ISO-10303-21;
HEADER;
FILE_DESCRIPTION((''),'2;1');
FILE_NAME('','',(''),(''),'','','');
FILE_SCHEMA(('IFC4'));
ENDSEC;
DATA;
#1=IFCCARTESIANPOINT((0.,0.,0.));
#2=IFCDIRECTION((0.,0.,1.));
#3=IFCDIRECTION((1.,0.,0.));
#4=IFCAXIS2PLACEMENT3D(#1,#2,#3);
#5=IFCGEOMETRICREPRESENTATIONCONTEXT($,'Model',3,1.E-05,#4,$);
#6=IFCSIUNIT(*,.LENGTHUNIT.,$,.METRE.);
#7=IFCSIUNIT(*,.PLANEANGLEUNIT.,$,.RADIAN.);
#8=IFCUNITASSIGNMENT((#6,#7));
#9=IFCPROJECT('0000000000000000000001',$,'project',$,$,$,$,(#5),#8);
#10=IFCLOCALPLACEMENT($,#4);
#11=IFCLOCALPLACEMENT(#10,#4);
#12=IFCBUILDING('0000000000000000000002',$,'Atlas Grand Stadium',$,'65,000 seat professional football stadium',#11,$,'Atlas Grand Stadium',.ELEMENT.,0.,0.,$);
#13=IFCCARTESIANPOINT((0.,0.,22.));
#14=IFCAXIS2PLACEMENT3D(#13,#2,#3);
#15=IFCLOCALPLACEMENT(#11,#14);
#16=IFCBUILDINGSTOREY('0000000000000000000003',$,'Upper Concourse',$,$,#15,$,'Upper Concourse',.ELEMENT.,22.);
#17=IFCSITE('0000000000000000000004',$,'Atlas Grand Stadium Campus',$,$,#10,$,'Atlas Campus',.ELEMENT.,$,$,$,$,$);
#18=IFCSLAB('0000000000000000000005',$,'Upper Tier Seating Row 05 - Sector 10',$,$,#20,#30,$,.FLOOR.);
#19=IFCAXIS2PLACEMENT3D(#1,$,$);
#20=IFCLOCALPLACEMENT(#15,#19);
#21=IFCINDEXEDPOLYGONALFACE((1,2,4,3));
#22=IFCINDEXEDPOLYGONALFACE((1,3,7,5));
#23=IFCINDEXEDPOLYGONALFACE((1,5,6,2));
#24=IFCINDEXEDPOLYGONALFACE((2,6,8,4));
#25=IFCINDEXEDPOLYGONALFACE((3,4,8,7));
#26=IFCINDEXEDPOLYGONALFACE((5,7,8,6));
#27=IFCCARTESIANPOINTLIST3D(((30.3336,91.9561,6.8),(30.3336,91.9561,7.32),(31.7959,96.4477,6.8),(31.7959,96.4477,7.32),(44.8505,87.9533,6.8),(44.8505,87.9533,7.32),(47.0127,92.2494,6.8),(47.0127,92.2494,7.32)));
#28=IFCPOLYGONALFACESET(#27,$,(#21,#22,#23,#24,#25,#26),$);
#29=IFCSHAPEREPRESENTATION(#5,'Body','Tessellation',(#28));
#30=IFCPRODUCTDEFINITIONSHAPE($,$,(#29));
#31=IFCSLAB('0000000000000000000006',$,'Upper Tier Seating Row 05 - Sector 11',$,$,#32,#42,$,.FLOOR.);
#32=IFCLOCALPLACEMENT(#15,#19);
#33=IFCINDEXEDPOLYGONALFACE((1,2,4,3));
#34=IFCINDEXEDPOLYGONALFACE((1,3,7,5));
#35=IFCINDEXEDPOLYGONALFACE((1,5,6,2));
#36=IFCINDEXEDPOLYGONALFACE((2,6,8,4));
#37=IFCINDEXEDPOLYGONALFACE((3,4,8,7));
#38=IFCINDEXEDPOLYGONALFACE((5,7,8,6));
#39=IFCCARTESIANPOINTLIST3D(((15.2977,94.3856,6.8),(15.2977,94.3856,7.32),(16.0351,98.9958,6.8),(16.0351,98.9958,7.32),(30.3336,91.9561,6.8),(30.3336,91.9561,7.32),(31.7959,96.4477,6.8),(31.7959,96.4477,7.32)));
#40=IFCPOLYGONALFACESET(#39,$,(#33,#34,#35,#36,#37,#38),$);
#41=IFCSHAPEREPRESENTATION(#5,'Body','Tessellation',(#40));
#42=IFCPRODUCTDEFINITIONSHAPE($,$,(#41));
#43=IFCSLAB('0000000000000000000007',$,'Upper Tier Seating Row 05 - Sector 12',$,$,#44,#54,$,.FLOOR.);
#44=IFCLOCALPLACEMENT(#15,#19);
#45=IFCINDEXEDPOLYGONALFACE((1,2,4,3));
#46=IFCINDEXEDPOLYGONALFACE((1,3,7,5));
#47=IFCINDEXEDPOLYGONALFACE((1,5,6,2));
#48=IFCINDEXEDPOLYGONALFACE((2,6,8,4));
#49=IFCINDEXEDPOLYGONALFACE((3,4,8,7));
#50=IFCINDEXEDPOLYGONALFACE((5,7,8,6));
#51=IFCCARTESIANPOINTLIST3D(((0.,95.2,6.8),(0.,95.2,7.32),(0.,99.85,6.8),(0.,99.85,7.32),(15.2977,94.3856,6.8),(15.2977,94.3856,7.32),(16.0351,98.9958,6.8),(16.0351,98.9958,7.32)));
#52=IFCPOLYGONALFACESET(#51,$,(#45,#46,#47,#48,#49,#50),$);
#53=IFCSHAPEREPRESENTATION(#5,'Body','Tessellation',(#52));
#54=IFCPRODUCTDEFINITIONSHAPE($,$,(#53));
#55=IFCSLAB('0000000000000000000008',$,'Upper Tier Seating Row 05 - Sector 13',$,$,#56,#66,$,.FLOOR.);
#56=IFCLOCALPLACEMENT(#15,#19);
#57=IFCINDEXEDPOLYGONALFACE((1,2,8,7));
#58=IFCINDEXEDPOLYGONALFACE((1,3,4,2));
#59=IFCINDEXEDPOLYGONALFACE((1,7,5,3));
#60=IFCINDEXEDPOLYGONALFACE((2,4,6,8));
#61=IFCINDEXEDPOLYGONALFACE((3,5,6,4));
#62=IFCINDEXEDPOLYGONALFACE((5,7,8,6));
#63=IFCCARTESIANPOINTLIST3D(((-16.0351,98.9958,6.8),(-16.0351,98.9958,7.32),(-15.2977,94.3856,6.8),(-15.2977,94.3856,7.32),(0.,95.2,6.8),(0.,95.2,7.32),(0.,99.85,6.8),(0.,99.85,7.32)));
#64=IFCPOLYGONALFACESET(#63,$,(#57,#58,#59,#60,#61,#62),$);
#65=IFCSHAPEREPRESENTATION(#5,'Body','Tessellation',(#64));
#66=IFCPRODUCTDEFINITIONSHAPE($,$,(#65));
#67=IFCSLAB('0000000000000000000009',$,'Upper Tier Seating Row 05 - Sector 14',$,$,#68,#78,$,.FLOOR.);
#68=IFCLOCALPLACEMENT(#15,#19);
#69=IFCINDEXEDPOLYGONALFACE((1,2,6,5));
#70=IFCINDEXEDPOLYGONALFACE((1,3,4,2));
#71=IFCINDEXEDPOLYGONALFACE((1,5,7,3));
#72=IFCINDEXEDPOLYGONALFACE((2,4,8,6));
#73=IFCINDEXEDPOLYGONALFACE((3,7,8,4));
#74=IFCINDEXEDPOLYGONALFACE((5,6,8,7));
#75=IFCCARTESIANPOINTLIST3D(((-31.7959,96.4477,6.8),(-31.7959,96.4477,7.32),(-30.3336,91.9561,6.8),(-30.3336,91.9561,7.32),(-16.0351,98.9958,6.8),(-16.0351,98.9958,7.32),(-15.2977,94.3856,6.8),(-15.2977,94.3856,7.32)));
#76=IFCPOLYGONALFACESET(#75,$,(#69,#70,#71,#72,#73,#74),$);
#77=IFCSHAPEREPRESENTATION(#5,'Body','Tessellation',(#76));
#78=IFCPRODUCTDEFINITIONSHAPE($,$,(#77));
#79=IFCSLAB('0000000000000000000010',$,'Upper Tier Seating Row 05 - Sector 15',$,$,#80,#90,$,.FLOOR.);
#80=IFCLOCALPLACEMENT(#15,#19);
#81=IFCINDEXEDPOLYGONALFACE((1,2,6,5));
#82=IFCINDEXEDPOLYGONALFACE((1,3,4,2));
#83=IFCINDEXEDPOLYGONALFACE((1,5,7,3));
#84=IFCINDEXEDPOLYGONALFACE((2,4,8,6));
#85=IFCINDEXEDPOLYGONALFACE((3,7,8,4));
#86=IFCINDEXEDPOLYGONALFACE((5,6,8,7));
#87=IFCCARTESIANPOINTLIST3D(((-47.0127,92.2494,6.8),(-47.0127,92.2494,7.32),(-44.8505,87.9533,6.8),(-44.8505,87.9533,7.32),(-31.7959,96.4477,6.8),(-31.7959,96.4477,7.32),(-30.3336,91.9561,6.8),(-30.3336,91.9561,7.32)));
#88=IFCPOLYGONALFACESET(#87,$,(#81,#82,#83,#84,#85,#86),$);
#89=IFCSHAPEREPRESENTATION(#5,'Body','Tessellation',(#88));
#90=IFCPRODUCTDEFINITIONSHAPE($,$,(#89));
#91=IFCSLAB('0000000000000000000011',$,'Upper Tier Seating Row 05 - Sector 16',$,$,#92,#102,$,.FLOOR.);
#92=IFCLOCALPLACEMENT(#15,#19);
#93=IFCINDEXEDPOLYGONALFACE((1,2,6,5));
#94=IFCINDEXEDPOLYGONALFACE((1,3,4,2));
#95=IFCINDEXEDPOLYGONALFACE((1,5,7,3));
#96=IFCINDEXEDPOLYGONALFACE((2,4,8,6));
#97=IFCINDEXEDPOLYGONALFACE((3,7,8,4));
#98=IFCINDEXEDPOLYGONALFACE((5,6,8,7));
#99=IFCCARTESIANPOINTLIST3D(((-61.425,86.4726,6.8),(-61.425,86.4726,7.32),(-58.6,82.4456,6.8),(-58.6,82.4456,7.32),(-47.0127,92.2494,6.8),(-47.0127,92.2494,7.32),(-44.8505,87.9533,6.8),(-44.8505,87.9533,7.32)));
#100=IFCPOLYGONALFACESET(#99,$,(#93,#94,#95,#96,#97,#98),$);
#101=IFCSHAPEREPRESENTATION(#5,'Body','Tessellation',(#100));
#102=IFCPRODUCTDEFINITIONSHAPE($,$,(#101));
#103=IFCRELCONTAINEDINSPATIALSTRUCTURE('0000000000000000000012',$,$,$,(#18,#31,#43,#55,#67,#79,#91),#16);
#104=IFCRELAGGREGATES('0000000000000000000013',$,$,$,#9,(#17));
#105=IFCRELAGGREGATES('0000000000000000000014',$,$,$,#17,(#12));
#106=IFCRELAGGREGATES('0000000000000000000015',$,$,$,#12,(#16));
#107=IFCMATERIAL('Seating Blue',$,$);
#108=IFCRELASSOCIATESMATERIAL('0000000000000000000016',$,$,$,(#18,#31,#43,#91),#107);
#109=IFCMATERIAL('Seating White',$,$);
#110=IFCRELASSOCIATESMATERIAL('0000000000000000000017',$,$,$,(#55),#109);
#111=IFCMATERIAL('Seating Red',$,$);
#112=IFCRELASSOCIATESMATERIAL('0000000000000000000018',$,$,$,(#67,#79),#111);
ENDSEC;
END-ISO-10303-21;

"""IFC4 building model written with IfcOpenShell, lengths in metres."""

from ifc_helpers import new_model, si_unit, frame, origin_with_axes, place, context, project, spatial, polyline, outline, extrude, material, element, save


model = new_model("IFC4")

# Units and contexts
model_context = context("Model", 3, precision=1e-05, world=origin_with_axes())
ifc_project = project(units=[si_unit("LENGTHUNIT", "METRE"), si_unit("PLANEANGLEUNIT", "RADIAN")], contexts=[model_context])

# Site, building, storey
site_placement = place(None, origin_with_axes())
site = spatial("IfcSite", under=ifc_project, at=site_placement, Name="Atlas Grand Stadium Campus", LongName="Atlas Campus", CompositionType="ELEMENT")
building_placement = place(site_placement, origin_with_axes())
building = spatial("IfcBuilding", under=site, at=building_placement, Name="Atlas Grand Stadium", ObjectType="65,000 seat professional football stadium", LongName="Atlas Grand Stadium", CompositionType="ELEMENT", ElevationOfRefHeight=0.0, ElevationOfTerrain=0.0)
storey_placement = place(building_placement, frame((0.0, 0.0, 22.0), z_axis=(0.0, 0.0, 1.0), x_axis=(1.0, 0.0, 0.0)))
storey = spatial("IfcBuildingStorey", under=building, at=storey_placement, Name="Upper Concourse", LongName="Upper Concourse", CompositionType="ELEMENT", Elevation=22.0)

# Slabs
ifc_material_1 = material(Name="Seating Blue")
ifc_material_2 = material(Name="Seating White")
ifc_material_3 = material(Name="Seating Red")
slab_1_placement = place(storey_placement, frame((0.0, 0.0, 6.8), z_axis=(0.0, 0.0, 1.0), x_axis=(1.0, 0.0, 0.0)))
element("IfcSlab", 1, at=slab_1_placement, inside=storey, material=ifc_material_1, Name="Upper Tier Seating Row 05 - Sector 10", PredefinedType="FLOOR", context=model_context, shape_type="SweptSolid", body=[
    extrude(outline(polyline([(47.0127, 92.2494), (31.7959, 96.4477), (30.3336, 91.9561), (44.8505, 87.9533), (47.0127, 92.2494)])), origin_with_axes(), (0.0, 0.0, 1.0), 0.52),
])
slab_2_placement = place(storey_placement, frame((0.0, 0.0, 6.8), z_axis=(0.0, 0.0, 1.0), x_axis=(1.0, 0.0, 0.0)))
element("IfcSlab", 2, at=slab_2_placement, inside=storey, material=ifc_material_1, Name="Upper Tier Seating Row 05 - Sector 11", PredefinedType="FLOOR", context=model_context, shape_type="SweptSolid", body=[
    extrude(outline(polyline([(31.7959, 96.4477), (16.0351, 98.9958), (15.2977, 94.3855), (30.3336, 91.9561), (31.7959, 96.4477)])), origin_with_axes(), (0.0, 0.0, 1.0), 0.52),
])
slab_3_placement = place(storey_placement, frame((0.0, 0.0, 6.8), z_axis=(0.0, 0.0, 1.0), x_axis=(1.0, 0.0, 0.0)))
element("IfcSlab", 3, at=slab_3_placement, inside=storey, material=ifc_material_1, Name="Upper Tier Seating Row 05 - Sector 12", PredefinedType="FLOOR", context=model_context, shape_type="SweptSolid", body=[
    extrude(outline(polyline([(16.0351, 98.9958), (0.0, 99.85), (0.0, 95.2), (15.2977, 94.3855), (16.0351, 98.9958)])), origin_with_axes(), (0.0, 0.0, 1.0), 0.52),
])
slab_4_placement = place(storey_placement, frame((0.0, 0.0, 6.8), z_axis=(0.0, 0.0, 1.0), x_axis=(1.0, 0.0, 0.0)))
element("IfcSlab", 4, at=slab_4_placement, inside=storey, material=ifc_material_2, Name="Upper Tier Seating Row 05 - Sector 13", PredefinedType="FLOOR", context=model_context, shape_type="SweptSolid", body=[
    extrude(outline(polyline([(0.0, 99.85), (-16.0351, 98.9958), (-15.2977, 94.3855), (0.0, 95.2), (0.0, 99.85)])), origin_with_axes(), (0.0, 0.0, 1.0), 0.52),
])
slab_5_placement = place(storey_placement, frame((0.0, 0.0, 6.8), z_axis=(0.0, 0.0, 1.0), x_axis=(1.0, 0.0, 0.0)))
element("IfcSlab", 5, at=slab_5_placement, inside=storey, material=ifc_material_3, Name="Upper Tier Seating Row 05 - Sector 14", PredefinedType="FLOOR", context=model_context, shape_type="SweptSolid", body=[
    extrude(outline(polyline([(-16.0351, 98.9958), (-31.7959, 96.4477), (-30.3336, 91.9561), (-15.2977, 94.3855), (-16.0351, 98.9958)])), origin_with_axes(), (0.0, 0.0, 1.0), 0.52),
])
slab_6_placement = place(storey_placement, frame((0.0, 0.0, 6.8), z_axis=(0.0, 0.0, 1.0), x_axis=(1.0, 0.0, 0.0)))
element("IfcSlab", 6, at=slab_6_placement, inside=storey, material=ifc_material_3, Name="Upper Tier Seating Row 05 - Sector 15", PredefinedType="FLOOR", context=model_context, shape_type="SweptSolid", body=[
    extrude(outline(polyline([(-31.7959, 96.4477), (-47.0127, 92.2494), (-44.8505, 87.9533), (-30.3336, 91.9561), (-31.7959, 96.4477)])), origin_with_axes(), (0.0, 0.0, 1.0), 0.52),
])
slab_7_placement = place(storey_placement, frame((0.0, 0.0, 6.8), z_axis=(0.0, 0.0, 1.0), x_axis=(1.0, 0.0, 0.0)))
element("IfcSlab", 7, at=slab_7_placement, inside=storey, material=ifc_material_1, Name="Upper Tier Seating Row 05 - Sector 16", PredefinedType="FLOOR", context=model_context, shape_type="SweptSolid", body=[
    extrude(outline(polyline([(-47.0127, 92.2494), (-61.425, 86.4726), (-58.6, 82.4456), (-44.8505, 87.9533), (-47.0127, 92.2494)])), origin_with_axes(), (0.0, 0.0, 1.0), 0.52),
])

save(model, "model.ifc")
